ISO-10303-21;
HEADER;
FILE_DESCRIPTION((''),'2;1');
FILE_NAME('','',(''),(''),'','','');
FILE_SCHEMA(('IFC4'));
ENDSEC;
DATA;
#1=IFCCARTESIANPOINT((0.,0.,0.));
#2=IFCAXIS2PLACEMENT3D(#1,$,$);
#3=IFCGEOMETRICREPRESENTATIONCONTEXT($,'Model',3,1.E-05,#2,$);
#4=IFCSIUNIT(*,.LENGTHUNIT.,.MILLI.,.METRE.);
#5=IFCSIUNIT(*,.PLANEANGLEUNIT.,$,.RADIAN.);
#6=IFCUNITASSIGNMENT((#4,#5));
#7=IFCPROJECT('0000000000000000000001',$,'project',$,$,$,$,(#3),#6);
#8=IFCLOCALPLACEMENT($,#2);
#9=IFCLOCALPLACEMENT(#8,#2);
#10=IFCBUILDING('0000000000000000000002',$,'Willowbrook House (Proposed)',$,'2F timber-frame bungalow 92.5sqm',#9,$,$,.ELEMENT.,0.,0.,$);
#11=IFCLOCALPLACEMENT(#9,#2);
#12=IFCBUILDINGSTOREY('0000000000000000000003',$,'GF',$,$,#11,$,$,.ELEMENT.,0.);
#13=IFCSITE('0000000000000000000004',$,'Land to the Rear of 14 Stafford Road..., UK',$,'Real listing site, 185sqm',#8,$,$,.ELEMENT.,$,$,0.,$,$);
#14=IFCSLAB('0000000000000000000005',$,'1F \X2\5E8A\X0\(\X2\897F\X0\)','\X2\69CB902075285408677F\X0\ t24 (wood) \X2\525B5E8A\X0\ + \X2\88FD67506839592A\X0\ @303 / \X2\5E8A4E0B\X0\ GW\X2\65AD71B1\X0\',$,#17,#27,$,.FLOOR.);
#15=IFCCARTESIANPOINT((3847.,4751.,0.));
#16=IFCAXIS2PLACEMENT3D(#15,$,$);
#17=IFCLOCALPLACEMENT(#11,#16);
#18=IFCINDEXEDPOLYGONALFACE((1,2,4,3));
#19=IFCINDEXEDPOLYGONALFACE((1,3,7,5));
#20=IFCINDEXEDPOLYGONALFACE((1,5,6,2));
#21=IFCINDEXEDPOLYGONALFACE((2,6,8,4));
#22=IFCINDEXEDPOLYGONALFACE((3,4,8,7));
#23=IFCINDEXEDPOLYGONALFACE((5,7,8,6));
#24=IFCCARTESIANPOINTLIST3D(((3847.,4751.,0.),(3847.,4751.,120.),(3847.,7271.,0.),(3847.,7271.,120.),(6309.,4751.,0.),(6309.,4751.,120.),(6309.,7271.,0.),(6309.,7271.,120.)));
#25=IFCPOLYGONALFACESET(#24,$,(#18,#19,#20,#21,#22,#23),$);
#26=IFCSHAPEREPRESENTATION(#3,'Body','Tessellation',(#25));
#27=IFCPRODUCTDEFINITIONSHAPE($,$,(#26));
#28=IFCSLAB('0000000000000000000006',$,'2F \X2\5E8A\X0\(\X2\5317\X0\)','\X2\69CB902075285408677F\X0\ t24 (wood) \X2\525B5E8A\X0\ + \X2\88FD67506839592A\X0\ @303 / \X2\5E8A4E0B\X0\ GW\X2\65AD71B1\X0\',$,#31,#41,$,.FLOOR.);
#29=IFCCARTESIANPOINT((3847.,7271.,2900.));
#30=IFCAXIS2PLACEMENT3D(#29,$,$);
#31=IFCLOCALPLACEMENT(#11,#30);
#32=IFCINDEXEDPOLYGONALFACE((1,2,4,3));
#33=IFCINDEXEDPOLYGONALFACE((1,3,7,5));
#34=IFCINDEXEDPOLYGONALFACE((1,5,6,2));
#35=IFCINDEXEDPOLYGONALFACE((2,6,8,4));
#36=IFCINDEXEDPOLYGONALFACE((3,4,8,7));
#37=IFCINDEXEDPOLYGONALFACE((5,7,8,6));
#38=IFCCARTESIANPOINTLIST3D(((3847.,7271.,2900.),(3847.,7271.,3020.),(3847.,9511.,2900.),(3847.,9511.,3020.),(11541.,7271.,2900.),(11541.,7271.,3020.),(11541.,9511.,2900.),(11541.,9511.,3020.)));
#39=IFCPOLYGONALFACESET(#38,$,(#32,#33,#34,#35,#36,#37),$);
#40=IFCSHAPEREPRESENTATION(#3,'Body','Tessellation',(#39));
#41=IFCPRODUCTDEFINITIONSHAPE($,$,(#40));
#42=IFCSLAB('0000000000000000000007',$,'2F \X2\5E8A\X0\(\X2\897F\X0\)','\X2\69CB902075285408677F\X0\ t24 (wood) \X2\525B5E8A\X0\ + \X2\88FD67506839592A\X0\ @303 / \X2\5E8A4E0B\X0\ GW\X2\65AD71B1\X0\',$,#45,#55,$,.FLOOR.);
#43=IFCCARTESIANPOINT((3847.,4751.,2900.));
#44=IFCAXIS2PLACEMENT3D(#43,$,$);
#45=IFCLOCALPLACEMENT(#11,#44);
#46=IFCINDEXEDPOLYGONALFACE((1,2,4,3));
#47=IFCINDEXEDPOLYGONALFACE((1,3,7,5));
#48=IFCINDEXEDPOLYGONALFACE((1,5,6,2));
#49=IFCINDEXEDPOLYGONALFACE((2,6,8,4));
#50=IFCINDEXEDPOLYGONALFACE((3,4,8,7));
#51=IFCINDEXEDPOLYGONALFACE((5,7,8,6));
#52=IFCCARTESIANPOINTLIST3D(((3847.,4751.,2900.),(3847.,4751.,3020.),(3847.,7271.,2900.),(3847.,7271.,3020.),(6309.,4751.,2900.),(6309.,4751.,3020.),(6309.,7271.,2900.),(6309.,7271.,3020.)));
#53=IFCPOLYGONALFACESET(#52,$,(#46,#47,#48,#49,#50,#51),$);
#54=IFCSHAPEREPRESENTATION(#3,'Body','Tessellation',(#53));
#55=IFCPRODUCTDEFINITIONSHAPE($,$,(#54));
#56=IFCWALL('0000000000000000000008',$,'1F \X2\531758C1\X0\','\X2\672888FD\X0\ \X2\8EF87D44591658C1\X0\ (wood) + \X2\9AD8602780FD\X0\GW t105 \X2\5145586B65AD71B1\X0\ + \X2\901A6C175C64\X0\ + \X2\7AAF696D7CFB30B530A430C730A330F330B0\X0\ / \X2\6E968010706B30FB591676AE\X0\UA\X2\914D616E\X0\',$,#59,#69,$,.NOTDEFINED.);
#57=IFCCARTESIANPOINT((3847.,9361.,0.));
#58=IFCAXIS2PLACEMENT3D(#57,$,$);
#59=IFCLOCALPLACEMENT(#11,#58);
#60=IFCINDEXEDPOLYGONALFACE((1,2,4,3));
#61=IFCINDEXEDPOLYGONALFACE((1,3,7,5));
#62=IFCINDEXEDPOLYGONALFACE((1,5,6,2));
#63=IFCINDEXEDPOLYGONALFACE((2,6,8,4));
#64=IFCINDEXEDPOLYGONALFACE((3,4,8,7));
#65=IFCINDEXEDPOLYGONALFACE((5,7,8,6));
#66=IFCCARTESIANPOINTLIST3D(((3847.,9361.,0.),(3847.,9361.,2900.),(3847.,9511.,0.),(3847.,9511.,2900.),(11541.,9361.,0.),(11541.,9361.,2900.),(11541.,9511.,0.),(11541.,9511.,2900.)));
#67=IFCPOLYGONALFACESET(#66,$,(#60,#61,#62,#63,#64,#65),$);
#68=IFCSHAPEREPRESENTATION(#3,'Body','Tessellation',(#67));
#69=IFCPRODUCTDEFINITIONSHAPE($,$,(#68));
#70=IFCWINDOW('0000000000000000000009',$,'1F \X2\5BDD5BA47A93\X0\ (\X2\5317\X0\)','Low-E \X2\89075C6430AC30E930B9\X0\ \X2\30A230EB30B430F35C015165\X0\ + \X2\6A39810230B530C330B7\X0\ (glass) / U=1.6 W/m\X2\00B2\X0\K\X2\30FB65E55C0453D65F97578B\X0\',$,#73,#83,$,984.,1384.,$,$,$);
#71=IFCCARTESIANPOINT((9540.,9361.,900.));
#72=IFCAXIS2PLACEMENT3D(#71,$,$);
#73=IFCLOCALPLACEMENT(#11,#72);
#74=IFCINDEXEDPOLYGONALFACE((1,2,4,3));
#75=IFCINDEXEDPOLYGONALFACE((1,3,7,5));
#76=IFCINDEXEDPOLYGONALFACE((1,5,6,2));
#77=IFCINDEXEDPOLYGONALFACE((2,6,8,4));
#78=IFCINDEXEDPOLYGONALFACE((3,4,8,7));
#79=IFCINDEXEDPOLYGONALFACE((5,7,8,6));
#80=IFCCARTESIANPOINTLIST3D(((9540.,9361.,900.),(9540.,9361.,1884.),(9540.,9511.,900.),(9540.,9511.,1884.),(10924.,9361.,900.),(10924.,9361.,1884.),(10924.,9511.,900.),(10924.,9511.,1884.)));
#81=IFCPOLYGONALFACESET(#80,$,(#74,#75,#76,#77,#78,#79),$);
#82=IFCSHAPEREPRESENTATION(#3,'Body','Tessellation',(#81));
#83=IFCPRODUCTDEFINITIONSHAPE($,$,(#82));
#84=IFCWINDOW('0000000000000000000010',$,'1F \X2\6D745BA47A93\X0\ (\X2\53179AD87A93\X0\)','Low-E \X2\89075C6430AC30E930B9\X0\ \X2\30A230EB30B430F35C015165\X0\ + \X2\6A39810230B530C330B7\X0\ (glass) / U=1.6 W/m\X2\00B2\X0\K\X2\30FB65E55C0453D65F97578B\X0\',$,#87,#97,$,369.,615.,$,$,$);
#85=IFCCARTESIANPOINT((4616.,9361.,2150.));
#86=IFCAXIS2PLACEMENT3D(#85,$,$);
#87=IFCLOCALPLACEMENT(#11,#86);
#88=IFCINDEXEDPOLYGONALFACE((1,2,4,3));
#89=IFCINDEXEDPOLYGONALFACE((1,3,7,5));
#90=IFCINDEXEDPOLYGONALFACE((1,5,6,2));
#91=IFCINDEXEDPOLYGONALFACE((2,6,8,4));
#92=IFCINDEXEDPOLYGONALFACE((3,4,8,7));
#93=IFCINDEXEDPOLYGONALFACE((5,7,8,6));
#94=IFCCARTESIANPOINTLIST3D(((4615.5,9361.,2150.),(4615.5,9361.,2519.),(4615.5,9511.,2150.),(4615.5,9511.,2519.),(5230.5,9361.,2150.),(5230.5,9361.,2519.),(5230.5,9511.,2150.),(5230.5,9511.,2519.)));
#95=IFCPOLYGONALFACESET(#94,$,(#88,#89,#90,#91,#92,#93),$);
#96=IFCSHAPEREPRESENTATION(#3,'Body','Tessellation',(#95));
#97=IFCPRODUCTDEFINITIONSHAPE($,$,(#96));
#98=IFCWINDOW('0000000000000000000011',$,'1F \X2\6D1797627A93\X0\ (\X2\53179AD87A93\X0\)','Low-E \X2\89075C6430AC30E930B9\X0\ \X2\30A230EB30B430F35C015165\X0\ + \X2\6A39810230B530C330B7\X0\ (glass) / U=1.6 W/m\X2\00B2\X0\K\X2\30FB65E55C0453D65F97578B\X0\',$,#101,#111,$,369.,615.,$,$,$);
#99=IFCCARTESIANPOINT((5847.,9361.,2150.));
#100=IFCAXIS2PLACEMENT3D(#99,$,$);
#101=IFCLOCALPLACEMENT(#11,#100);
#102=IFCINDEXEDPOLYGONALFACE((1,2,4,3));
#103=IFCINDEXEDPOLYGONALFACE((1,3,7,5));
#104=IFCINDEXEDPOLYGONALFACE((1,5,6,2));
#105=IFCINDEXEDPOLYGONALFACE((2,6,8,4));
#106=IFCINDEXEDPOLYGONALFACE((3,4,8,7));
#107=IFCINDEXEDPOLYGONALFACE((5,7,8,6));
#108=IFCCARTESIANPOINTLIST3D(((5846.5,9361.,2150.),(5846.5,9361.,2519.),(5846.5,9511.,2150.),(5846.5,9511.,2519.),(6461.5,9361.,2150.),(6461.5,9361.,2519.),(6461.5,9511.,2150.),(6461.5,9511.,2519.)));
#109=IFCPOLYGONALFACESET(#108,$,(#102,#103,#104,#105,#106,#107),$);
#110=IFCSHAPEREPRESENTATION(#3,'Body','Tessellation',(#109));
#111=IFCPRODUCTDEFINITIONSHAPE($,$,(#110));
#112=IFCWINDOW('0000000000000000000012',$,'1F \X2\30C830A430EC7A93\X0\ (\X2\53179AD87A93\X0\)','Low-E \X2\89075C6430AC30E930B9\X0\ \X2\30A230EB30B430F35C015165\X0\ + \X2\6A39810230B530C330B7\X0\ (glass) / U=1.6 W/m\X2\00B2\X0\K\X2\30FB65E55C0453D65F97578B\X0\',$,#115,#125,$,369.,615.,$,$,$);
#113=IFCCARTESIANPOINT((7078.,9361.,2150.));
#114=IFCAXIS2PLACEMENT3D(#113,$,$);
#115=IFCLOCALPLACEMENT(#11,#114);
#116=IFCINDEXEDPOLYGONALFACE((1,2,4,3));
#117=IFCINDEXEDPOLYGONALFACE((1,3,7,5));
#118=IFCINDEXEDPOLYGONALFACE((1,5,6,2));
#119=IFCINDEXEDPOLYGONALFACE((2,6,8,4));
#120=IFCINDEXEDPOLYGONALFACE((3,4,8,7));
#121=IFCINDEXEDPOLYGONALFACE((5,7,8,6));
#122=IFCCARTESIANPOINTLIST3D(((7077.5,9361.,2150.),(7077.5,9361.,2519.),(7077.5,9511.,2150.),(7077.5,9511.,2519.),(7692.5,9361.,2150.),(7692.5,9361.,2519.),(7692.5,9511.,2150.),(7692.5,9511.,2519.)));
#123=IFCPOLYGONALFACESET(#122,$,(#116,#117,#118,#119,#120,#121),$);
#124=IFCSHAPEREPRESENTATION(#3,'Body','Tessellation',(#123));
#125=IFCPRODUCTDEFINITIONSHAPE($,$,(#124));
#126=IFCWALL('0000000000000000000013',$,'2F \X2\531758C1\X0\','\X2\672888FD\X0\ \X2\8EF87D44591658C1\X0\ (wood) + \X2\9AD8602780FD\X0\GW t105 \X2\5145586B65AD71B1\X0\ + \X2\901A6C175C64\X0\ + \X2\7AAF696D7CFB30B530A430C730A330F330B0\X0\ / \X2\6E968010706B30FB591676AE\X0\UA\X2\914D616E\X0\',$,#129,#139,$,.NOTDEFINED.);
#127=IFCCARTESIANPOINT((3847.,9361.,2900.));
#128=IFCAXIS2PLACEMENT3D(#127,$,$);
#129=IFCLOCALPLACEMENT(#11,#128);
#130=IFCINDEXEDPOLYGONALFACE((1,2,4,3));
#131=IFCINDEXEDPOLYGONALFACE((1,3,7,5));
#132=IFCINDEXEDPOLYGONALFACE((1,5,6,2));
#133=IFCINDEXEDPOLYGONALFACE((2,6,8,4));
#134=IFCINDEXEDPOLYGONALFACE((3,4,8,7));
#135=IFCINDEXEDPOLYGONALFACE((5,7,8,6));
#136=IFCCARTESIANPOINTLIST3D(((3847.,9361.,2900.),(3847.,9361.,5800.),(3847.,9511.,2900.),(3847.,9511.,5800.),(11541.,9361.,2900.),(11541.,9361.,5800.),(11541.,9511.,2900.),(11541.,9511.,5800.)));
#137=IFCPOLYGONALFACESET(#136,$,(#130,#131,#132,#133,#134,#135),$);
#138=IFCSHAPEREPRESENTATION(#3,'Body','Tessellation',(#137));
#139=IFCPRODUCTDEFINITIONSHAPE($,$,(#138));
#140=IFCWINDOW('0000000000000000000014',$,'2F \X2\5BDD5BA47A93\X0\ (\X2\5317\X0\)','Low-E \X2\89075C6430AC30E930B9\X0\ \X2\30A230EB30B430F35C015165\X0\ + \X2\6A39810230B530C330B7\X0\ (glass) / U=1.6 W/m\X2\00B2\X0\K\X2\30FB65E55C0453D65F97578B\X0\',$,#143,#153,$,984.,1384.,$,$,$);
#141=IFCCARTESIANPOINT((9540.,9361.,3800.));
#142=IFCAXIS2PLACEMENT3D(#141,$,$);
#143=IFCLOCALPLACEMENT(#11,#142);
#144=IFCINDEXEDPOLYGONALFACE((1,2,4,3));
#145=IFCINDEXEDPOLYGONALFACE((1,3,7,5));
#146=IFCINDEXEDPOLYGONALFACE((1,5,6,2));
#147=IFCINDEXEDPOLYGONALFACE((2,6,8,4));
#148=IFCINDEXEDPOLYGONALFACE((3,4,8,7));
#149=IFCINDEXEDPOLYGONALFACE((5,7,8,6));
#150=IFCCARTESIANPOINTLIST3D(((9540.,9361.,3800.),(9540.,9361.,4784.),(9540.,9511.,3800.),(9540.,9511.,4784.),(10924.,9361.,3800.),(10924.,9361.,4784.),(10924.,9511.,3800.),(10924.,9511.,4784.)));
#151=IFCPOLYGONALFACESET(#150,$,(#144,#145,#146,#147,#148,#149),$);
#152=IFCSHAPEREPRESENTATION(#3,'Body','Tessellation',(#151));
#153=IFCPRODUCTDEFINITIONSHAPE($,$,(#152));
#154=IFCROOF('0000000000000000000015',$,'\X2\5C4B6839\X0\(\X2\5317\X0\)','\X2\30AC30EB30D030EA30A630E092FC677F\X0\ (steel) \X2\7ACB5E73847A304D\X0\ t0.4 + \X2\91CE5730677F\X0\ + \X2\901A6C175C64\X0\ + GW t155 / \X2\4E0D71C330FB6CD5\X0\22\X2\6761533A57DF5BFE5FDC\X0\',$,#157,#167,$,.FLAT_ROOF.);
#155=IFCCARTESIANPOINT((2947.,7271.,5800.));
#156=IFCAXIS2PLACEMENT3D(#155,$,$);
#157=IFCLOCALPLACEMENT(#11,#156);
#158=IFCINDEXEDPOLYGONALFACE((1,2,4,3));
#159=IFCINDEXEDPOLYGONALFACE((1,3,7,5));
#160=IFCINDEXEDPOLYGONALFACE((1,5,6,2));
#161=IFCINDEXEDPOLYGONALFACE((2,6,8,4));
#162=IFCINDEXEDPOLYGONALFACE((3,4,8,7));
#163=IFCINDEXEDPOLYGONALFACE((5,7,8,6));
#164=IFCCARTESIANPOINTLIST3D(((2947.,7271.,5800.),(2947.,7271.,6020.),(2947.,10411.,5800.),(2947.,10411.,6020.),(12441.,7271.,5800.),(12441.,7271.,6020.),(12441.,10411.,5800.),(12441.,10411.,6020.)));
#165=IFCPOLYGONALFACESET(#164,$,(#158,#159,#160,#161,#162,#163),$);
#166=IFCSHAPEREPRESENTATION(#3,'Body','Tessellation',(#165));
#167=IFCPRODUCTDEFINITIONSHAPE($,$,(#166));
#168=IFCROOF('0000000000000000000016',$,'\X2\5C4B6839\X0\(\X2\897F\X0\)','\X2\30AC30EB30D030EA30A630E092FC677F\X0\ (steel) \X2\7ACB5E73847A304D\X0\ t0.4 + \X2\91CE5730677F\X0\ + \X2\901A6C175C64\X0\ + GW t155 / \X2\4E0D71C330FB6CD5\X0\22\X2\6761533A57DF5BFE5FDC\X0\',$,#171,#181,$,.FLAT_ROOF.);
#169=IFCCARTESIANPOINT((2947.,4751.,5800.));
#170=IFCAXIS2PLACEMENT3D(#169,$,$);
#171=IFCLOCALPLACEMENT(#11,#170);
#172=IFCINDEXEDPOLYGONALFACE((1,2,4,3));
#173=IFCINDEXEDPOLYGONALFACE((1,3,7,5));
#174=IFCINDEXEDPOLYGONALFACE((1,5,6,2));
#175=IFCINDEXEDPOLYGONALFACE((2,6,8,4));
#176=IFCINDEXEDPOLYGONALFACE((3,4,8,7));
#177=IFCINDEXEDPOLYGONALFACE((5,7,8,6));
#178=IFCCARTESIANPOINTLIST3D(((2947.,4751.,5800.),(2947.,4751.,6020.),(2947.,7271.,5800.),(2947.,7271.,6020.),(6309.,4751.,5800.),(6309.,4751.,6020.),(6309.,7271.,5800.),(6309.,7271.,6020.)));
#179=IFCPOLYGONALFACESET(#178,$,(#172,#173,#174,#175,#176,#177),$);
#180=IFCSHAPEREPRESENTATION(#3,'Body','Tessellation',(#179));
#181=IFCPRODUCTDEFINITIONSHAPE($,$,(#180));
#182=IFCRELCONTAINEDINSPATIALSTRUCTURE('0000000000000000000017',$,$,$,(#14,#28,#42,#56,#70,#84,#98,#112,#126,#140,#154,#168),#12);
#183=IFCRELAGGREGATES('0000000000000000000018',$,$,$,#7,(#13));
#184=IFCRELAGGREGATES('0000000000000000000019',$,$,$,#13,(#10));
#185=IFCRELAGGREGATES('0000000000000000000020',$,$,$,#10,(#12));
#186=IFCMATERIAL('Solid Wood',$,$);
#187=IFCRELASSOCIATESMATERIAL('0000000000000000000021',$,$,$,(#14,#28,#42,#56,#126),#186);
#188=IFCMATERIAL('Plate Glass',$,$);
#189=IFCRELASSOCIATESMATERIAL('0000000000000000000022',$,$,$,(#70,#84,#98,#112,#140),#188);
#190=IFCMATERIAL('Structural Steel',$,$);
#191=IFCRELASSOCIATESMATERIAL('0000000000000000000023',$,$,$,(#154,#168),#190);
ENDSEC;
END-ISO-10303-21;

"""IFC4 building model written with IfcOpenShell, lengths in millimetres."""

from ifc_helpers import new_model, si_unit, frame, frame_2d, origin, place, context, project, spatial, rectangle, extrude, material, element, fill, save


model = new_model("IFC4")

# Units and contexts
model_context = context("Model", 3, precision=1e-05, world=origin())
ifc_project = project(units=[si_unit("LENGTHUNIT", "METRE", prefix="MILLI"), si_unit("PLANEANGLEUNIT", "RADIAN")], contexts=[model_context])

# Site, building, storey
site_placement = place(None, origin())
site = spatial("IfcSite", under=ifc_project, at=site_placement, Name="Land to the Rear of 14 Stafford Road..., UK", ObjectType="Real listing site, 185sqm", CompositionType="ELEMENT", RefElevation=0.0)
building_placement = place(site_placement, origin())
building = spatial("IfcBuilding", under=site, at=building_placement, Name="Willowbrook House (Proposed)", ObjectType="2F timber-frame bungalow 92.5sqm", CompositionType="ELEMENT", ElevationOfRefHeight=0.0, ElevationOfTerrain=0.0)
storey_placement = place(building_placement, origin())
storey = spatial("IfcBuildingStorey", under=building, at=storey_placement, Name="GF", CompositionType="ELEMENT", Elevation=0.0)

# Slabs
ifc_material_1 = material(Name="Solid Wood")
slab_1_placement = place(storey_placement, frame((3847.0, 4751.0, 0.0)))
element("IfcSlab", 1, at=slab_1_placement, inside=storey, material=ifc_material_1, Name="1F 床(西)", Description="構造用合板 t24 (wood) 剛床 + 製材根太 @303 / 床下 GW断熱", PredefinedType="FLOOR", context=model_context, shape_type="SweptSolid", body=[
    extrude(rectangle(XDim=2462.0, YDim=2520.0, at=frame_2d((1231.0, 1260.0))), frame((3847.0, 4751.0, 0.0)), (0.0, 0.0, 1.0), 120.0),
])
slab_2_placement = place(storey_placement, frame((3847.0, 7271.0, 2900.0)))
element("IfcSlab", 2, at=slab_2_placement, inside=storey, material=ifc_material_1, Name="2F 床(北)", Description="構造用合板 t24 (wood) 剛床 + 製材根太 @303 / 床下 GW断熱", PredefinedType="FLOOR", context=model_context, shape_type="SweptSolid", body=[
    extrude(rectangle(XDim=7694.0, YDim=2240.0, at=frame_2d((3847.0, 1120.0))), frame((3847.0, 7271.0, 2900.0)), (0.0, 0.0, 1.0), 120.0),
])
slab_3_placement = place(storey_placement, frame((3847.0, 4751.0, 2900.0)))
element("IfcSlab", 3, at=slab_3_placement, inside=storey, material=ifc_material_1, Name="2F 床(西)", Description="構造用合板 t24 (wood) 剛床 + 製材根太 @303 / 床下 GW断熱", PredefinedType="FLOOR", context=model_context, shape_type="SweptSolid", body=[
    extrude(rectangle(XDim=2462.0, YDim=2520.0, at=frame_2d((1231.0, 1260.0))), frame((3847.0, 4751.0, 2900.0)), (0.0, 0.0, 1.0), 120.0),
])

# Wall, openings, windows
wall_1_placement = place(storey_placement, frame((3847.0, 9361.0, 0.0)))
wall_1 = element("IfcWall", 4, at=wall_1_placement, inside=storey, material=ifc_material_1, Name="1F 北壁", Description="木製 軸組外壁 (wood) + 高性能GW t105 充填断熱 + 通気層 + 窯業系サイディング / 準耐火・外皮UA配慮", PredefinedType="NOTDEFINED", context=model_context, shape_type="SweptSolid", body=[
    extrude(rectangle(XDim=7694.0, YDim=150.0, at=frame_2d((3847.0, 75.0))), frame((3847.0, 9361.0, 0.0)), (0.0, 0.0, 1.0), 2900.0),
])
opening_1_placement = place(storey_placement, frame((9540.0, 9361.0, 900.0)))
opening_1 = element("IfcOpeningElement", 5, at=opening_1_placement, cuts=wall_1, PredefinedType="NOTDEFINED", context=model_context, shape_type="SweptSolid", body=[
    extrude(rectangle(XDim=1384.0, YDim=150.0, at=frame_2d((692.0, 75.0))), frame((9540.0, 9361.0, 900.0)), (0.0, 0.0, 1.0), 984.0),
])
opening_2_placement = place(storey_placement, frame((4616.0, 9361.0, 2150.0)))
opening_2 = element("IfcOpeningElement", 6, at=opening_2_placement, cuts=wall_1, PredefinedType="NOTDEFINED", context=model_context, shape_type="SweptSolid", body=[
    extrude(rectangle(XDim=615.0, YDim=150.0, at=frame_2d((307.0, 75.0))), frame((4616.0, 9361.0, 2150.0)), (0.0, 0.0, 1.0), 369.0),
])
opening_3_placement = place(storey_placement, frame((5847.0, 9361.0, 2150.0)))
opening_3 = element("IfcOpeningElement", 7, at=opening_3_placement, cuts=wall_1, PredefinedType="NOTDEFINED", context=model_context, shape_type="SweptSolid", body=[
    extrude(rectangle(XDim=615.0, YDim=150.0, at=frame_2d((307.0, 75.0))), frame((5847.0, 9361.0, 2150.0)), (0.0, 0.0, 1.0), 369.0),
])
opening_4_placement = place(storey_placement, frame((7078.0, 9361.0, 2150.0)))
opening_4 = element("IfcOpeningElement", 8, at=opening_4_placement, cuts=wall_1, PredefinedType="NOTDEFINED", context=model_context, shape_type="SweptSolid", body=[
    extrude(rectangle(XDim=615.0, YDim=150.0, at=frame_2d((307.0, 75.0))), frame((7078.0, 9361.0, 2150.0)), (0.0, 0.0, 1.0), 369.0),
])
ifc_material_2 = material(Name="Plate Glass")
window_1_placement = place(storey_placement, frame((9540.0, 9361.0, 900.0)))
window_1 = element("IfcWindow", 9, at=window_1_placement, inside=storey, material=ifc_material_2, Name="1F 寝室窓 (北)", Description="Low-E 複層ガラス アルゴン封入 + 樹脂サッシ (glass) / U=1.6 W/m²K・日射取得型", OverallHeight=984.0, OverallWidth=1384.0, context=model_context, shape_type="SweptSolid", body=[
    extrude(rectangle(XDim=1384.0, YDim=150.0, at=frame_2d((692.0, 75.0))), frame((9540.0, 9361.0, 900.0)), (0.0, 0.0, 1.0), 984.0),
])
fill(opening_1, window_1)
window_2_placement = place(storey_placement, frame((4616.0, 9361.0, 2150.0)))
window_2 = element("IfcWindow", 10, at=window_2_placement, inside=storey, material=ifc_material_2, Name="1F 浴室窓 (北高窓)", Description="Low-E 複層ガラス アルゴン封入 + 樹脂サッシ (glass) / U=1.6 W/m²K・日射取得型", OverallHeight=369.0, OverallWidth=615.0, context=model_context, shape_type="SweptSolid", body=[
    extrude(rectangle(XDim=615.0, YDim=150.0, at=frame_2d((307.0, 75.0))), frame((4616.0, 9361.0, 2150.0)), (0.0, 0.0, 1.0), 369.0),
])
fill(opening_2, window_2)
window_3_placement = place(storey_placement, frame((5847.0, 9361.0, 2150.0)))
window_3 = element("IfcWindow", 11, at=window_3_placement, inside=storey, material=ifc_material_2, Name="1F 洗面窓 (北高窓)", Description="Low-E 複層ガラス アルゴン封入 + 樹脂サッシ (glass) / U=1.6 W/m²K・日射取得型", OverallHeight=369.0, OverallWidth=615.0, context=model_context, shape_type="SweptSolid", body=[
    extrude(rectangle(XDim=615.0, YDim=150.0, at=frame_2d((307.0, 75.0))), frame((5847.0, 9361.0, 2150.0)), (0.0, 0.0, 1.0), 369.0),
])
fill(opening_3, window_3)
window_4_placement = place(storey_placement, frame((7078.0, 9361.0, 2150.0)))
window_4 = element("IfcWindow", 12, at=window_4_placement, inside=storey, material=ifc_material_2, Name="1F トイレ窓 (北高窓)", Description="Low-E 複層ガラス アルゴン封入 + 樹脂サッシ (glass) / U=1.6 W/m²K・日射取得型", OverallHeight=369.0, OverallWidth=615.0, context=model_context, shape_type="SweptSolid", body=[
    extrude(rectangle(XDim=615.0, YDim=150.0, at=frame_2d((307.0, 75.0))), frame((7078.0, 9361.0, 2150.0)), (0.0, 0.0, 1.0), 369.0),
])
fill(opening_4, window_4)

# Wall, opening, window
wall_2_placement = place(storey_placement, frame((3847.0, 9361.0, 2900.0)))
wall_2 = element("IfcWall", 13, at=wall_2_placement, inside=storey, material=ifc_material_1, Name="2F 北壁", Description="木製 軸組外壁 (wood) + 高性能GW t105 充填断熱 + 通気層 + 窯業系サイディング / 準耐火・外皮UA配慮", PredefinedType="NOTDEFINED", context=model_context, shape_type="SweptSolid", body=[
    extrude(rectangle(XDim=7694.0, YDim=150.0, at=frame_2d((3847.0, 75.0))), frame((3847.0, 9361.0, 2900.0)), (0.0, 0.0, 1.0), 2900.0),
])
opening_5_placement = place(storey_placement, frame((9540.0, 9361.0, 3800.0)))
opening_5 = element("IfcOpeningElement", 14, at=opening_5_placement, cuts=wall_2, PredefinedType="NOTDEFINED", context=model_context, shape_type="SweptSolid", body=[
    extrude(rectangle(XDim=1384.0, YDim=150.0, at=frame_2d((692.0, 75.0))), frame((9540.0, 9361.0, 3800.0)), (0.0, 0.0, 1.0), 984.0),
])
window_5_placement = place(storey_placement, frame((9540.0, 9361.0, 3800.0)))
window_5 = element("IfcWindow", 15, at=window_5_placement, inside=storey, material=ifc_material_2, Name="2F 寝室窓 (北)", Description="Low-E 複層ガラス アルゴン封入 + 樹脂サッシ (glass) / U=1.6 W/m²K・日射取得型", OverallHeight=984.0, OverallWidth=1384.0, context=model_context, shape_type="SweptSolid", body=[
    extrude(rectangle(XDim=1384.0, YDim=150.0, at=frame_2d((692.0, 75.0))), frame((9540.0, 9361.0, 3800.0)), (0.0, 0.0, 1.0), 984.0),
])
fill(opening_5, window_5)

# Roofs
ifc_material_3 = material(Name="Structural Steel")
for number, where, name in (
    (16, (2947.0, 7271.0, 5800.0), "屋根(北)"),
):
    element("IfcRoof", number, at=place(storey_placement, frame(where)), inside=storey, material=ifc_material_3, Name=name, Description="ガルバリウム鋼板 (steel) 立平葺き t0.4 + 野地板 + 通気層 + GW t155 / 不燃・法22条区域対応", PredefinedType="FLAT_ROOF", context=model_context, shape_type="SweptSolid", body=[
        extrude(rectangle(XDim=9494.0, YDim=3140.0, at=frame_2d((4747.0, 1570.0))), frame((2947.0, 7271.0, 5800.0)), (0.0, 0.0, 1.0), 220.0),
    ])
roof_placement = place(storey_placement, frame((2947.0, 4751.0, 5800.0)))
element("IfcRoof", 17, at=roof_placement, inside=storey, material=ifc_material_3, Name="屋根(西)", Description="ガルバリウム鋼板 (steel) 立平葺き t0.4 + 野地板 + 通気層 + GW t155 / 不燃・法22条区域対応", PredefinedType="FLAT_ROOF", context=model_context, shape_type="SweptSolid", body=[
    extrude(rectangle(XDim=3362.0, YDim=2520.0, at=frame_2d((1681.0, 1260.0))), frame((2947.0, 4751.0, 5800.0)), (0.0, 0.0, 1.0), 220.0),
])

save(model, "model.ifc")
